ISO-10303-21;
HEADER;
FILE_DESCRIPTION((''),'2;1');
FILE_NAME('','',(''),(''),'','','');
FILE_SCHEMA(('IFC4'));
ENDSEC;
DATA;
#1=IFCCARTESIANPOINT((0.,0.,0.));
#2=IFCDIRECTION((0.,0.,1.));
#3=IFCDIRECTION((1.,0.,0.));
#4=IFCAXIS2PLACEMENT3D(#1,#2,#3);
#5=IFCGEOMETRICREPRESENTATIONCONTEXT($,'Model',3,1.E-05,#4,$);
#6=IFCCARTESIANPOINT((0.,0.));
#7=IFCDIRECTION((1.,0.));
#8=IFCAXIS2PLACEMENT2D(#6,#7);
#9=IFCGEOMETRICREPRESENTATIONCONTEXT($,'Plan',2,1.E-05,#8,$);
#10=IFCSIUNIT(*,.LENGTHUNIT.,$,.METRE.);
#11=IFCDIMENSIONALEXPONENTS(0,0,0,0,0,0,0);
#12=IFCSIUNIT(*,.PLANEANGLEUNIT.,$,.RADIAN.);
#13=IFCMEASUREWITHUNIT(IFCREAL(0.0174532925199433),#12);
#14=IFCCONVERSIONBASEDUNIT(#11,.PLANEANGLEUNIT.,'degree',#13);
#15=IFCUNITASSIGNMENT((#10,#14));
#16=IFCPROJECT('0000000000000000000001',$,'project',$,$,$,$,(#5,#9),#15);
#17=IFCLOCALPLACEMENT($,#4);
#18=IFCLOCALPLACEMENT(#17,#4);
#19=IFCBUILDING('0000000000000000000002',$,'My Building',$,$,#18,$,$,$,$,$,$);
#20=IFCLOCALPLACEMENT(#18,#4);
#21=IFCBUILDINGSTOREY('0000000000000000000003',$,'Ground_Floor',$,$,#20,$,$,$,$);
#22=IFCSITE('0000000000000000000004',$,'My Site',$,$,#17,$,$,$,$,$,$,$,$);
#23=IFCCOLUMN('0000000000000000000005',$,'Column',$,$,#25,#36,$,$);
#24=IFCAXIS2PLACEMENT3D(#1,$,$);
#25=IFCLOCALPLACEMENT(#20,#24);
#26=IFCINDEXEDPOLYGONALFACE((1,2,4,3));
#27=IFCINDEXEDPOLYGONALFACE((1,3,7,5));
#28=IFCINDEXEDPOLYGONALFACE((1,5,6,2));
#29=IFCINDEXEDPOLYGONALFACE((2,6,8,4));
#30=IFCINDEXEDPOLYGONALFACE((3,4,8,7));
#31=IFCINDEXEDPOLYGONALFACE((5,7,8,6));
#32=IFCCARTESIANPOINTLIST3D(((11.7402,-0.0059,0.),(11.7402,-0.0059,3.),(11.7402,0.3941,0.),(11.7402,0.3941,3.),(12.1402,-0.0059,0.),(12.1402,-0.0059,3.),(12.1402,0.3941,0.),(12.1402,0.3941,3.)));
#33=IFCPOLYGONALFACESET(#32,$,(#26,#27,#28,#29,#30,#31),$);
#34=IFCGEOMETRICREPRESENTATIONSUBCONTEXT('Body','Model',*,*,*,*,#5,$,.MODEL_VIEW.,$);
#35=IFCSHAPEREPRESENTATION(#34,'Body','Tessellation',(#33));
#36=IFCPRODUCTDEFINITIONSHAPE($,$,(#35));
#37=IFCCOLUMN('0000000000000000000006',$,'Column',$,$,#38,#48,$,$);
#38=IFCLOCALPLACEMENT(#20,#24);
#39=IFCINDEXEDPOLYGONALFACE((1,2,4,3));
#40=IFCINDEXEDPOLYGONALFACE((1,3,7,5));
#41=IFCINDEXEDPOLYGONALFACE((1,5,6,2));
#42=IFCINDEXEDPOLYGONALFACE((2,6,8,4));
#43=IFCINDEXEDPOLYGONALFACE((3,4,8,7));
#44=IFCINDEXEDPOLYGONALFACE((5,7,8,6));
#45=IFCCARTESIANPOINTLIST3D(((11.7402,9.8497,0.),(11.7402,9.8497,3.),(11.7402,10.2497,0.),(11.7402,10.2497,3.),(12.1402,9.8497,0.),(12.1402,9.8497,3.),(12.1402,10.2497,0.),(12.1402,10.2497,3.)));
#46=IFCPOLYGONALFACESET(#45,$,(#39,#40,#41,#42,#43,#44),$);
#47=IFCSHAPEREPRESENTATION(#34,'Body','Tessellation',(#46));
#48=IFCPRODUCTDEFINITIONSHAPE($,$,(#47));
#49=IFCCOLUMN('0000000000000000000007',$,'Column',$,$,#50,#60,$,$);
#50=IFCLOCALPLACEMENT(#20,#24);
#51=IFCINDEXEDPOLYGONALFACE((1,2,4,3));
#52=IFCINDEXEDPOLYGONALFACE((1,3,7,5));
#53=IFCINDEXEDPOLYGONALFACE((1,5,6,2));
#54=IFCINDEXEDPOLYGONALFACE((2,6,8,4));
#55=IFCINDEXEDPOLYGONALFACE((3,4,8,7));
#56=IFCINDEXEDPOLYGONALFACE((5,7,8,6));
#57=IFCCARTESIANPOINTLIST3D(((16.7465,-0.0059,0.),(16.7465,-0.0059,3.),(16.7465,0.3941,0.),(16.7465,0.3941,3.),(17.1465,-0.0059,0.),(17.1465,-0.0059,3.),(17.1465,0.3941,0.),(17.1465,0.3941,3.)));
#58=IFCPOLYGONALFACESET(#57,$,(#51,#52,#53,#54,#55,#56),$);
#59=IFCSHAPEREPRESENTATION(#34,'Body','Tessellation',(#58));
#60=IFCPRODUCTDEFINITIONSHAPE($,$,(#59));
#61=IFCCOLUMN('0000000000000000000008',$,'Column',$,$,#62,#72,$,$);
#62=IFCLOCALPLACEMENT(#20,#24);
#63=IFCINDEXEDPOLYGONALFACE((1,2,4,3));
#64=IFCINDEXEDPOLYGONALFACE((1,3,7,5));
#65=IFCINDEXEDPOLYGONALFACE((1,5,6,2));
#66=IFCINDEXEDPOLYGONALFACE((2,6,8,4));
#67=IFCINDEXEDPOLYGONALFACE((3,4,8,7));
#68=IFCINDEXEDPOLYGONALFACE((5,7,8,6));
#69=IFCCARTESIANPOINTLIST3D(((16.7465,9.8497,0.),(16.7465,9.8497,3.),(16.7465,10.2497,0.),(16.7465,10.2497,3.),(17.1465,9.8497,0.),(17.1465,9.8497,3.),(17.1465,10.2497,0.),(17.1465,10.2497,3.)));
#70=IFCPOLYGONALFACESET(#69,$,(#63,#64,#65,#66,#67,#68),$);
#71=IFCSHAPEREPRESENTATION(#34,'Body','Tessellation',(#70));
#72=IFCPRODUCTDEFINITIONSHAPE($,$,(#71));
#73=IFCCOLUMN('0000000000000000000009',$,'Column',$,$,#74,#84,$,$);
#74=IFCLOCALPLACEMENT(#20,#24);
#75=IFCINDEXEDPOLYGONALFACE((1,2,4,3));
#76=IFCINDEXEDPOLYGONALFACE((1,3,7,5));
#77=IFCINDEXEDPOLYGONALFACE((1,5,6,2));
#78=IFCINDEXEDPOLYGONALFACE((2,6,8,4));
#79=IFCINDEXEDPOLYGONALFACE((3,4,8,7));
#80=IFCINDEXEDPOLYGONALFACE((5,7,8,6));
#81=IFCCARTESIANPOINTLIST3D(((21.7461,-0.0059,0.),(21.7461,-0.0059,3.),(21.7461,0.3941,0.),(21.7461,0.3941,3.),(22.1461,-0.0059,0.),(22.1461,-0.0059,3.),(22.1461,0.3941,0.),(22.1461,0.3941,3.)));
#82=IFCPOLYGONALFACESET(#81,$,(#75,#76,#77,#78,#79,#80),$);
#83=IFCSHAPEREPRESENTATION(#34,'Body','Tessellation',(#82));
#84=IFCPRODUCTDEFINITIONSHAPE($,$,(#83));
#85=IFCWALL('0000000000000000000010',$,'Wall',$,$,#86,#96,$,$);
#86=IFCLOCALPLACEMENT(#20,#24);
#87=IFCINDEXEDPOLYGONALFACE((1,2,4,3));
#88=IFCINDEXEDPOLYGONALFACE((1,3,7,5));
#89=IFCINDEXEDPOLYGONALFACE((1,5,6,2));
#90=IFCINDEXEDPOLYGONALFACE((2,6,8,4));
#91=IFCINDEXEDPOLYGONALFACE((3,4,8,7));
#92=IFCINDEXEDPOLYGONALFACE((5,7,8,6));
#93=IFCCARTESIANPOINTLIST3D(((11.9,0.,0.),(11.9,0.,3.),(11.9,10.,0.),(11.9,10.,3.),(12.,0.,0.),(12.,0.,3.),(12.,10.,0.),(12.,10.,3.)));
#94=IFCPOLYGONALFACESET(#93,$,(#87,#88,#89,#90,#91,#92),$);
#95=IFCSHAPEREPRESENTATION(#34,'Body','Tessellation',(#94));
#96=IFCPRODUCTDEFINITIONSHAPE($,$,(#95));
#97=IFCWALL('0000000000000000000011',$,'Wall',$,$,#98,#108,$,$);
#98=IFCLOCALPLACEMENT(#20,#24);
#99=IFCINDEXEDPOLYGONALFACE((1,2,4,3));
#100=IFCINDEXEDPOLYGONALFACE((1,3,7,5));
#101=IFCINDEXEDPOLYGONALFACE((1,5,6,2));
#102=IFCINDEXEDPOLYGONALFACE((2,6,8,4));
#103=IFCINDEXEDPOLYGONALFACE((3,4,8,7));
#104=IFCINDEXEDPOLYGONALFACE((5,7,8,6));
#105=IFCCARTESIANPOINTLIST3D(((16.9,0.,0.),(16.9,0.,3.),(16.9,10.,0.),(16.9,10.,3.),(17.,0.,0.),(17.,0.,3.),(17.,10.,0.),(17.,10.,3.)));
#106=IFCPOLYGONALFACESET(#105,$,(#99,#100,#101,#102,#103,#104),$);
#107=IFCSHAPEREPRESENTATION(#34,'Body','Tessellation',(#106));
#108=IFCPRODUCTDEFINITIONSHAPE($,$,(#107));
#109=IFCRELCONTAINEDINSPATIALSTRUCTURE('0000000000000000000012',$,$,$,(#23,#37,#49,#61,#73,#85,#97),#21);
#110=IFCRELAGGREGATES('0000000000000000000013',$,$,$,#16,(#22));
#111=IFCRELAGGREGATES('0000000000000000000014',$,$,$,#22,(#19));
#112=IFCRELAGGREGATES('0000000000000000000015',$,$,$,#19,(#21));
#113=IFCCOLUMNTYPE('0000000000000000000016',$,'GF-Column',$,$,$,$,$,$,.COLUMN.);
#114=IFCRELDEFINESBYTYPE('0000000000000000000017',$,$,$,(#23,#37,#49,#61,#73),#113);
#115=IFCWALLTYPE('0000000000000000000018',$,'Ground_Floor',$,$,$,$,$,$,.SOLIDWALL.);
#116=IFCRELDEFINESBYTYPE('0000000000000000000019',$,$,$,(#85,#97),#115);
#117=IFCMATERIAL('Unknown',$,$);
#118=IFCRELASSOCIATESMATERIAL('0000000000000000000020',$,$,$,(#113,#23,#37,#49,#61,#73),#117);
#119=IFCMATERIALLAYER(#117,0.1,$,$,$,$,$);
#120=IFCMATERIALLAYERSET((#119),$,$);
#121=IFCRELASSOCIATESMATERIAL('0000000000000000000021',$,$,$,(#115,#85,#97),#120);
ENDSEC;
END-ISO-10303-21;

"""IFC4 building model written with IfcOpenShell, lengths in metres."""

from ifc_helpers import new_model, entity, si_unit, converted_unit, frame, origin_with_axes, origin_2d_with_axis, place, context, subcontext, project, spatial, line, indexed_curve, rectangle, outline, extrude, material, layer, layer_set, layer_usage, material_profile, profile_set, profile_usage, type_object, element, save


model = new_model("IFC4")

# Units and contexts
model_context = context("Model", 3, precision=1e-05, world=origin_with_axes())
plan_context = context("Plan", 2, precision=1e-05, world=origin_2d_with_axis())
body_context_1 = subcontext(model_context, "Body", "Model", "MODEL_VIEW")
ifc_project = project(units=[si_unit("LENGTHUNIT", "METRE"), converted_unit("PLANEANGLEUNIT", "degree", entity("IfcReal", 0.0174532925199433), si_unit("PLANEANGLEUNIT", "RADIAN"), dimensions=[0, 0, 0, 0, 0, 0, 0])], contexts=[model_context, plan_context])

# Site, building, storey
site_placement = place(None, origin_with_axes())
site = spatial("IfcSite", under=ifc_project, at=site_placement, Name="My Site")
building_placement = place(site_placement, origin_with_axes())
building = spatial("IfcBuilding", under=site, at=building_placement, Name="My Building")
storey_placement = place(building_placement, origin_with_axes())
storey = spatial("IfcBuildingStorey", under=building, at=storey_placement, Name="Ground_Floor")

# Columns
ifc_material = material(Name="Unknown")
ifc_material_profile = material_profile(ifc_material, rectangle(XDim=0.4, YDim=0.4))
ifc_profile_set = profile_set([ifc_material_profile])
ifc_profile_usage_1 = profile_usage(ifc_profile_set, cardinal=5)
column_type = type_object("IfcColumnType", Name="GF-Column", PredefinedType="COLUMN", material=ifc_profile_set)
column_1_placement = place(storey_placement, frame((11.9402, 0.1941, 0.0), z_axis=(0.0, 0.0, 1.0), x_axis=(1.0, 0.0, 0.0)))
element("IfcColumn", 1, at=column_1_placement, inside=storey, type_object=column_type, material=ifc_profile_usage_1, Name="Column", context=body_context_1, shape_type="SweptSolid", body=[
    extrude(rectangle(XDim=0.4, YDim=0.4), origin_with_axes(), (0.0, 0.0, 1.0), 3.0),
])
ifc_profile_usage_2 = profile_usage(ifc_profile_set, cardinal=5)
column_2_placement = place(storey_placement, frame((11.9402, 10.0497, 0.0), z_axis=(0.0, 0.0, 1.0), x_axis=(1.0, 0.0, 0.0)))
element("IfcColumn", 2, at=column_2_placement, inside=storey, type_object=column_type, material=ifc_profile_usage_2, Name="Column", context=body_context_1, shape_type="SweptSolid", body=[
    extrude(rectangle(XDim=0.4, YDim=0.4), origin_with_axes(), (0.0, 0.0, 1.0), 3.0),
])
ifc_profile_usage_3 = profile_usage(ifc_profile_set, cardinal=5)
column_3_placement = place(storey_placement, frame((16.9465, 0.1941, 0.0), z_axis=(0.0, 0.0, 1.0), x_axis=(1.0, 0.0, 0.0)))
element("IfcColumn", 3, at=column_3_placement, inside=storey, type_object=column_type, material=ifc_profile_usage_3, Name="Column", context=body_context_1, shape_type="SweptSolid", body=[
    extrude(rectangle(XDim=0.4, YDim=0.4), origin_with_axes(), (0.0, 0.0, 1.0), 3.0),
])
ifc_profile_usage_4 = profile_usage(ifc_profile_set, cardinal=5)
column_4_placement = place(storey_placement, frame((16.9465, 10.0497, 0.0), z_axis=(0.0, 0.0, 1.0), x_axis=(1.0, 0.0, 0.0)))
element("IfcColumn", 4, at=column_4_placement, inside=storey, type_object=column_type, material=ifc_profile_usage_4, Name="Column", context=body_context_1, shape_type="SweptSolid", body=[
    extrude(rectangle(XDim=0.4, YDim=0.4), origin_with_axes(), (0.0, 0.0, 1.0), 3.0),
])
ifc_profile_usage_5 = profile_usage(ifc_profile_set, cardinal=5)
column_5_placement = place(storey_placement, frame((21.9461, 0.1941, 0.0), z_axis=(0.0, 0.0, 1.0), x_axis=(1.0, 0.0, 0.0)))
element("IfcColumn", 5, at=column_5_placement, inside=storey, type_object=column_type, material=ifc_profile_usage_5, Name="Column", context=body_context_1, shape_type="SweptSolid", body=[
    extrude(rectangle(XDim=0.4, YDim=0.4), origin_with_axes(), (0.0, 0.0, 1.0), 3.0),
])

# Walls
ifc_layer = layer(ifc_material, 0.1)
ifc_layer_set = layer_set([ifc_layer])
ifc_layer_usage_1 = layer_usage(ifc_layer_set, "AXIS2", "POSITIVE", 0.0)
wall_type = type_object("IfcWallType", Name="Ground_Floor", PredefinedType="SOLIDWALL", material=ifc_layer_set)
wall_1_placement = place(storey_placement, frame((12.0, 0.0, 0.0), z_axis=(0.0, 0.0, 1.0), x_axis=(0.0, 1.0, 0.0)))
element("IfcWall", 6, at=wall_1_placement, inside=storey, type_object=wall_type, material=ifc_layer_usage_1, Name="Wall", context=body_context_1, shape_type="SweptSolid", body=[
    extrude(outline(indexed_curve([(0.0, 0.0), (0.0, 0.1), (10.0, 0.1), (10.0, 0.0)], segments=[line(1, 2, 3, 4, 1)])), origin_with_axes(), (0.0, 0.0, 1.0), 3.0),
])
ifc_layer_usage_2 = layer_usage(ifc_layer_set, "AXIS2", "POSITIVE", 0.0)
wall_2_placement = place(storey_placement, frame((17.0, 0.0, 0.0), z_axis=(0.0, 0.0, 1.0), x_axis=(0.0, 1.0, 0.0)))
element("IfcWall", 7, at=wall_2_placement, inside=storey, type_object=wall_type, material=ifc_layer_usage_2, Name="Wall", context=body_context_1, shape_type="SweptSolid", body=[
    extrude(outline(indexed_curve([(0.0, 0.0), (0.0, 0.1), (10.0, 0.1), (10.0, 0.0)], segments=[line(1, 2, 3, 4, 1)])), origin_with_axes(), (0.0, 0.0, 1.0), 3.0),
])

save(model, "model.ifc")
